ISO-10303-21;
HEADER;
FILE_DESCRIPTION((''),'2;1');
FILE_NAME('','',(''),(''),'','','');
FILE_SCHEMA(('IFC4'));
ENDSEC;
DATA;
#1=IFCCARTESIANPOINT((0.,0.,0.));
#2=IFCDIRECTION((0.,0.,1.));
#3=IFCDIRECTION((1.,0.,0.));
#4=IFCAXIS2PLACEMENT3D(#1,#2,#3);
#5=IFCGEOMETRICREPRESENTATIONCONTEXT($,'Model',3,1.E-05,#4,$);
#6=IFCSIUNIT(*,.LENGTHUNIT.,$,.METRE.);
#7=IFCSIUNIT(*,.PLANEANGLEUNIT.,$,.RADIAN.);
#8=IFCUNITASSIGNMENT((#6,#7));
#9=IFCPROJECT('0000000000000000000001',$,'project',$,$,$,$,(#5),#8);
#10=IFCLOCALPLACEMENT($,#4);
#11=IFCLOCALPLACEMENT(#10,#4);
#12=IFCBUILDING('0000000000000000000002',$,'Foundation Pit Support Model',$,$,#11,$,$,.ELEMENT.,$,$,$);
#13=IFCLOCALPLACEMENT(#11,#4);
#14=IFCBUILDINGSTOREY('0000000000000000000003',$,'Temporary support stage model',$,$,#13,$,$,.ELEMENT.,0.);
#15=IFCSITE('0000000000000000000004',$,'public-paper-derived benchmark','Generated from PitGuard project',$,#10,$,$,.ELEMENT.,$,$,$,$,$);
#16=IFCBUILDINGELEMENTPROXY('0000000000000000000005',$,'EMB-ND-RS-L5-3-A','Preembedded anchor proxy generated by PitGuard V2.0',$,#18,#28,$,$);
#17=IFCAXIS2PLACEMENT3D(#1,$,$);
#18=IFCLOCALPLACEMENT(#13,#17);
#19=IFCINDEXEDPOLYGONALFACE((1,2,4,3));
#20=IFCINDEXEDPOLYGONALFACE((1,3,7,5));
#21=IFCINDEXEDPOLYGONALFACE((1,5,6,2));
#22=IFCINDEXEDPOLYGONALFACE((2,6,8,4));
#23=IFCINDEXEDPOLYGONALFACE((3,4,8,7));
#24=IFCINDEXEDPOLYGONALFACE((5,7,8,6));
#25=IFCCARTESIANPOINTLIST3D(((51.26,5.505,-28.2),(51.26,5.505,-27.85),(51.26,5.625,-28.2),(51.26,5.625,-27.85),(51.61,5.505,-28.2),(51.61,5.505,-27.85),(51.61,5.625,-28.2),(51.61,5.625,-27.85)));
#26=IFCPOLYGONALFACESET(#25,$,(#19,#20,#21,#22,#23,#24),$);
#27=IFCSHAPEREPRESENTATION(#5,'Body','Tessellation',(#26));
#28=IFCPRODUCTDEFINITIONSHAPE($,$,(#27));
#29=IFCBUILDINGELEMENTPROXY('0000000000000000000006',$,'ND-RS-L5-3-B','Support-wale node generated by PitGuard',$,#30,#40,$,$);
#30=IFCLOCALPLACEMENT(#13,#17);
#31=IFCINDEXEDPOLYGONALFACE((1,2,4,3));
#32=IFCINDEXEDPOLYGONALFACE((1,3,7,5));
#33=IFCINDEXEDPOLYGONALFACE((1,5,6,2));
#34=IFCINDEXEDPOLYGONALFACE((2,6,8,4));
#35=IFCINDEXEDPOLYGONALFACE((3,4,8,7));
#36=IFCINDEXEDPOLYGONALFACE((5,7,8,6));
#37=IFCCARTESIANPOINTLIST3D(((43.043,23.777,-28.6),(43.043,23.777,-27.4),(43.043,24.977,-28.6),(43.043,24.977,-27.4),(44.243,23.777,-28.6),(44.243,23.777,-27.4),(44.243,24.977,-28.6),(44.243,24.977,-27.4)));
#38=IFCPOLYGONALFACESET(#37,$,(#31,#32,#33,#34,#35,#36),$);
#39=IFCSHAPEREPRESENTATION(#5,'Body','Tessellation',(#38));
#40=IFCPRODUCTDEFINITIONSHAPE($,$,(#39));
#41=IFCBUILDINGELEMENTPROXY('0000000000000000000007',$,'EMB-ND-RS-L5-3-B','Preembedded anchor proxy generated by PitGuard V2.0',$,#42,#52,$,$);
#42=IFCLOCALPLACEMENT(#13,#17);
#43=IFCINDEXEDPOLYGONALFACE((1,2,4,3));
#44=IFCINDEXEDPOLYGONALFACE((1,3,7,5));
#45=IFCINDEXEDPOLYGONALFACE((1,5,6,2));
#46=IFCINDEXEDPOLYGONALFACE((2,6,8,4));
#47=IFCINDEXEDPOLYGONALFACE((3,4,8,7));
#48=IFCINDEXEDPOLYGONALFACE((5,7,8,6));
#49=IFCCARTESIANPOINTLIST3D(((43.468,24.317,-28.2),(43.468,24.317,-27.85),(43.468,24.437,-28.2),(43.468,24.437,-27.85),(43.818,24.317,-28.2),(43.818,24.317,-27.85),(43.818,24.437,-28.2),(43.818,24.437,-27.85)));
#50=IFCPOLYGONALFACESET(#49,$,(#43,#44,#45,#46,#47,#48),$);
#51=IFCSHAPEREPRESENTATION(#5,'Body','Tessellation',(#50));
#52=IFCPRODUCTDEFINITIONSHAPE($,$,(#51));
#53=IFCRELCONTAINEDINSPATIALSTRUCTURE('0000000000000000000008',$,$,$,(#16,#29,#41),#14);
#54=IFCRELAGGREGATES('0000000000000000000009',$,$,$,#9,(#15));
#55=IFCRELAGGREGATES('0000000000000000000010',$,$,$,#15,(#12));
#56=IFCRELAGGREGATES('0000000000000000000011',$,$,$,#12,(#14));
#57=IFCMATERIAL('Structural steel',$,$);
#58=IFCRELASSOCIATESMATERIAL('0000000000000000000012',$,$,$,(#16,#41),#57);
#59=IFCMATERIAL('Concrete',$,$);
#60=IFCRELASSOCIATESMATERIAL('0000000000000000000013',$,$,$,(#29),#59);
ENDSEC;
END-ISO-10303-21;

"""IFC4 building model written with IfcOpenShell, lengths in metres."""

from ifc_helpers import new_model, si_unit, frame, origin_with_axes, origin_2d, place, context, project, spatial, rectangle, extrude, material, element, save


model = new_model("IFC4")

# Units and contexts
model_context = context("Model", 3, precision=1e-05, world=origin_with_axes())
ifc_project = project(units=[si_unit("LENGTHUNIT", "METRE"), si_unit("PLANEANGLEUNIT", "RADIAN")], contexts=[model_context])

# Site, building, storey
site_placement = place(None, origin_with_axes())
site = spatial("IfcSite", under=ifc_project, at=site_placement, Name="public-paper-derived benchmark", Description="Generated from PitGuard project", CompositionType="ELEMENT")
building_placement = place(site_placement, origin_with_axes())
building = spatial("IfcBuilding", under=site, at=building_placement, Name="Foundation Pit Support Model", CompositionType="ELEMENT")
storey_placement = place(building_placement, origin_with_axes())
storey = spatial("IfcBuildingStorey", under=building, at=storey_placement, Name="Temporary support stage model", CompositionType="ELEMENT", Elevation=0.0)

# Shared definitions
ifc_material_1 = material(Name="Structural steel")

# Shared definitions
ifc_material_2 = material(Name="Concrete")

# Building element proxies
proxy_1_placement = place(storey_placement, frame((51.435, 5.565, -28.2), z_axis=(0.0, 0.0, 1.0), x_axis=(1.0, 0.0, 0.0)))
element("IfcBuildingElementProxy", 1, at=proxy_1_placement, inside=storey, material=ifc_material_1, Name="EMB-ND-RS-L5-3-A", Description="Preembedded anchor proxy generated by PitGuard V2.0", context=model_context, shape_type="SweptSolid", body=[
    extrude(rectangle(XDim=0.35, YDim=0.12, at=origin_2d()), origin_with_axes(), (0.0, 0.0, 1.0), 0.35),
])
proxy_2_placement = place(storey_placement, frame((43.643, 24.377, -28.6), z_axis=(0.0, 0.0, 1.0), x_axis=(1.0, 0.0, 0.0)))
element("IfcBuildingElementProxy", 2, at=proxy_2_placement, inside=storey, material=ifc_material_2, Name="ND-RS-L5-3-B", Description="Support-wale node generated by PitGuard", context=model_context, shape_type="SweptSolid", body=[
    extrude(rectangle(XDim=1.2, YDim=1.2, at=origin_2d()), origin_with_axes(), (0.0, 0.0, 1.0), 1.2),
])
proxy_3_placement = place(storey_placement, frame((43.643, 24.377, -28.2), z_axis=(0.0, 0.0, 1.0), x_axis=(1.0, 0.0, 0.0)))
element("IfcBuildingElementProxy", 3, at=proxy_3_placement, inside=storey, material=ifc_material_1, Name="EMB-ND-RS-L5-3-B", Description="Preembedded anchor proxy generated by PitGuard V2.0", context=model_context, shape_type="SweptSolid", body=[
    extrude(rectangle(XDim=0.35, YDim=0.12, at=origin_2d()), origin_with_axes(), (0.0, 0.0, 1.0), 0.35),
])

save(model, "model.ifc")
